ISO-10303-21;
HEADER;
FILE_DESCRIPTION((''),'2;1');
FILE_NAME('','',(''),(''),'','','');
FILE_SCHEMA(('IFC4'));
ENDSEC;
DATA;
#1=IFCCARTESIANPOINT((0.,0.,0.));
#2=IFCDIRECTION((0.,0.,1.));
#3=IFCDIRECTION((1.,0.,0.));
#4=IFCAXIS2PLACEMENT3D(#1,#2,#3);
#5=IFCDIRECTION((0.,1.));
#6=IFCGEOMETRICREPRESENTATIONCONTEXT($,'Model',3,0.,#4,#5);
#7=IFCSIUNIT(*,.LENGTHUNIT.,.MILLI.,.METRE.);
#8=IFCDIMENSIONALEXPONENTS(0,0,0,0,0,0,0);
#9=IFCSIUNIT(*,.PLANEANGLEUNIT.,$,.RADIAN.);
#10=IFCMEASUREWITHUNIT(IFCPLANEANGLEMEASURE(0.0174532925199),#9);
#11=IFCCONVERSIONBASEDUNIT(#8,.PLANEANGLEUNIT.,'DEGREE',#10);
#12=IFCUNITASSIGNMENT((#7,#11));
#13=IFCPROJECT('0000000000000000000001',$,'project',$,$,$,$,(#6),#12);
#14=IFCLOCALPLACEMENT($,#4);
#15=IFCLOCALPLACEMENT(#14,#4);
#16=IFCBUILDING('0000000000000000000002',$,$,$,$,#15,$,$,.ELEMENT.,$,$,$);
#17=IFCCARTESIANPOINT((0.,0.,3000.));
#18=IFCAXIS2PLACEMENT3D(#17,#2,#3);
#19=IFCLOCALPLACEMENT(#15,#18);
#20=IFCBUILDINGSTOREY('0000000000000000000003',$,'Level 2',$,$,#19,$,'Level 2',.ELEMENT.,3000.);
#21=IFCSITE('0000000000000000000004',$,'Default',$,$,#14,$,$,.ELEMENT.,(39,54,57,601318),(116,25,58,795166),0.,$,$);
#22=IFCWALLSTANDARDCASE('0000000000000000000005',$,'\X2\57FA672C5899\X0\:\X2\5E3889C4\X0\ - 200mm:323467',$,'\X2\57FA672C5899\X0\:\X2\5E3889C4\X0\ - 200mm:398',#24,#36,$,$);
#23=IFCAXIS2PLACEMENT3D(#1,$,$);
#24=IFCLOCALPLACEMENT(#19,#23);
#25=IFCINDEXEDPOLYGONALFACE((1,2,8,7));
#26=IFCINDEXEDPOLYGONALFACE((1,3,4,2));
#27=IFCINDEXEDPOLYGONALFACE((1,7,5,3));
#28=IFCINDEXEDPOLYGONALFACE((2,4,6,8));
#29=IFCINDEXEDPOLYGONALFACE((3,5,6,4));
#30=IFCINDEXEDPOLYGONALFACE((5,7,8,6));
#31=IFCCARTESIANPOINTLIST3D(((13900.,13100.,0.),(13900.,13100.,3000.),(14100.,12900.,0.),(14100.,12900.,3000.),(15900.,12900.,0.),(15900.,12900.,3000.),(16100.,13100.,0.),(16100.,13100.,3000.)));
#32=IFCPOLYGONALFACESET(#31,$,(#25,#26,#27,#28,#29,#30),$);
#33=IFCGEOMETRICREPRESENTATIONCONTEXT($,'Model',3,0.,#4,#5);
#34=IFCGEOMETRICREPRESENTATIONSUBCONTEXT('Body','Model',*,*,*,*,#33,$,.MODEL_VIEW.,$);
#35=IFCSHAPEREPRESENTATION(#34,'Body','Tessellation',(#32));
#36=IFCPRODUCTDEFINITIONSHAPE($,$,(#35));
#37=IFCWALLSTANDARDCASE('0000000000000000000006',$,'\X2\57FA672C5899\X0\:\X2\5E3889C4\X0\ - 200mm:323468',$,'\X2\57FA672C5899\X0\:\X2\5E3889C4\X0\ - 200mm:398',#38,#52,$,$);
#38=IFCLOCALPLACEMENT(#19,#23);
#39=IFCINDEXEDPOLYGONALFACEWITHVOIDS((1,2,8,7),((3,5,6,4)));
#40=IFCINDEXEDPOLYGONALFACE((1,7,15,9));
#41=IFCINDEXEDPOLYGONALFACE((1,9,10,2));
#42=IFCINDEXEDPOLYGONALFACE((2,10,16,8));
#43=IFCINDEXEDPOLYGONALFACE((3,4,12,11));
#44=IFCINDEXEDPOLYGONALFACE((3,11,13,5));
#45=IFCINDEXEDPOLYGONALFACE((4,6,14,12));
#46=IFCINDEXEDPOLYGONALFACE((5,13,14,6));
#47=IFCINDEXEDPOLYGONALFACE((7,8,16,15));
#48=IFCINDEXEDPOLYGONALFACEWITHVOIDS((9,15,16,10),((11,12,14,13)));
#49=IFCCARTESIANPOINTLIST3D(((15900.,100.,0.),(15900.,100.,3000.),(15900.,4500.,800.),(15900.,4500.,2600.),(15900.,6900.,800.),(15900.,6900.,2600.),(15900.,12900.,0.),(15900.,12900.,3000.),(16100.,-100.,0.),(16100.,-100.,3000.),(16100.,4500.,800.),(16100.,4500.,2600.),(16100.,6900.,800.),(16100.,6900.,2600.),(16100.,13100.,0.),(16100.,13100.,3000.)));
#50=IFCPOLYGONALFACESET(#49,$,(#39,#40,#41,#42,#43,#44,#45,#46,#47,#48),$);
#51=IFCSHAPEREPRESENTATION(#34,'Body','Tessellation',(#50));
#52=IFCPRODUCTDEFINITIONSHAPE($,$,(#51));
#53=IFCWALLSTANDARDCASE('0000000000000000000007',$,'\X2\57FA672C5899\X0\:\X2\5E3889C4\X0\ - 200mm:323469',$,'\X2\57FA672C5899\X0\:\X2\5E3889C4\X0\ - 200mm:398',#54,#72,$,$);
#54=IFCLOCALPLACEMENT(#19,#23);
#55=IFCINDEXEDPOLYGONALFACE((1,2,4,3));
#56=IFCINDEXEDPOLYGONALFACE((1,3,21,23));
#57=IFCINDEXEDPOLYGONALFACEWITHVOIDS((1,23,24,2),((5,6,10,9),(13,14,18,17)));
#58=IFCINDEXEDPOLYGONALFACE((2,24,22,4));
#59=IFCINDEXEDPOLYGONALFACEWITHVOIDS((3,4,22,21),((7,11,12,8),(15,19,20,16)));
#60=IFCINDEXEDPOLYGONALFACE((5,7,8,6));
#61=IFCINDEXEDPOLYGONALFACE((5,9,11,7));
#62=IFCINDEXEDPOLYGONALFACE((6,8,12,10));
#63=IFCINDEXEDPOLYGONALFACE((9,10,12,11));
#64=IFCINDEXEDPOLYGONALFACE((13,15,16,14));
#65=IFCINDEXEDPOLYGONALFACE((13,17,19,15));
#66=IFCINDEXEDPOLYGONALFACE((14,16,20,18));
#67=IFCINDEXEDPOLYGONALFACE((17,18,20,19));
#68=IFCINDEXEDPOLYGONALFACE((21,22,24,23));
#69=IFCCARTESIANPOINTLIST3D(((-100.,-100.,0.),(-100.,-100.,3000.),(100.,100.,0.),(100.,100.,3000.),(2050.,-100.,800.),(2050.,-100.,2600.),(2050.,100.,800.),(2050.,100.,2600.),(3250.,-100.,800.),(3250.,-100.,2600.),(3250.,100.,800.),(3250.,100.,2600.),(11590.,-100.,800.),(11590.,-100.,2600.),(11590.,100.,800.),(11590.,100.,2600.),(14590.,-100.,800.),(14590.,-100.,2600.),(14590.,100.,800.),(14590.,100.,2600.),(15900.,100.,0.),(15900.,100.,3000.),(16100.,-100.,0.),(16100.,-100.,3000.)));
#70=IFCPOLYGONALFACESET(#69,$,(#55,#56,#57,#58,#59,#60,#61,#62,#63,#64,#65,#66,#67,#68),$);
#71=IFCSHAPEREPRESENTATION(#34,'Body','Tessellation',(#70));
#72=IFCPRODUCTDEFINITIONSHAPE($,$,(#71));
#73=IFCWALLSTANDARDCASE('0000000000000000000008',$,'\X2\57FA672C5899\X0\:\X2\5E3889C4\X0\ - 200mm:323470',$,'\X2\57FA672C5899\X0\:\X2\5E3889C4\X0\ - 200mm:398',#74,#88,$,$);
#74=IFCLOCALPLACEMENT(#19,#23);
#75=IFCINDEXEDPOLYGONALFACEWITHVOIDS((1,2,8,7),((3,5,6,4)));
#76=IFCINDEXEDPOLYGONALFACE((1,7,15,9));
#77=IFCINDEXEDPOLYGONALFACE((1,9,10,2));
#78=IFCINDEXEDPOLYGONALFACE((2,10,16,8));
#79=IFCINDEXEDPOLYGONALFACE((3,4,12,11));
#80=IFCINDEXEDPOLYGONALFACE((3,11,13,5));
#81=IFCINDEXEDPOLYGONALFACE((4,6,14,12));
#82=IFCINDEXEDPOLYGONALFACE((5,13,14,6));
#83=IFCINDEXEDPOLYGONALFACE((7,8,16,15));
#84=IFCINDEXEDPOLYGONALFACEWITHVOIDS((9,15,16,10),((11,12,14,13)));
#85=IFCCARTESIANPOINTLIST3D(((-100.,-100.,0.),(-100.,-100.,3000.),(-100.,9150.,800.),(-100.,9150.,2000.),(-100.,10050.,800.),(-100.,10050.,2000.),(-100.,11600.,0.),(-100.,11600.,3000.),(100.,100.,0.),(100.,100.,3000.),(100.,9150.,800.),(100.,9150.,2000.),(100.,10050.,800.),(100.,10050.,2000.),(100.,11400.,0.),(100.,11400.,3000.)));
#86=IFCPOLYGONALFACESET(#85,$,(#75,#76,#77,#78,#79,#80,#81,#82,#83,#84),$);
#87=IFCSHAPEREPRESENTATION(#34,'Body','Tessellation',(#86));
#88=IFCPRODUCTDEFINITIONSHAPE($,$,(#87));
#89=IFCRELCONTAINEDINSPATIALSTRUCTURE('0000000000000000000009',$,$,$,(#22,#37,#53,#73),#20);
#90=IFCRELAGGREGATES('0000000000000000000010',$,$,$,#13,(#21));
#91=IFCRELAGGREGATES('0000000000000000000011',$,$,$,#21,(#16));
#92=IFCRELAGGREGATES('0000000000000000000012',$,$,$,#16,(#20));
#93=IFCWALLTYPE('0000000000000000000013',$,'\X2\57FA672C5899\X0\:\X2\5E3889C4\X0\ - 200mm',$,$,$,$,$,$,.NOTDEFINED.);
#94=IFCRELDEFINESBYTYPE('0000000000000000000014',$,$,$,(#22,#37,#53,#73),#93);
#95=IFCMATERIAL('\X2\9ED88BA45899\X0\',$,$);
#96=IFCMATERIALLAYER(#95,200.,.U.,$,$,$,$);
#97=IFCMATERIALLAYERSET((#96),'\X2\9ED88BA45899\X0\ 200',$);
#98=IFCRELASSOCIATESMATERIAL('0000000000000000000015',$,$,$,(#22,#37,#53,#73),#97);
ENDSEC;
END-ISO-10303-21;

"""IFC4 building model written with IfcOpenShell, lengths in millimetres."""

from ifc_helpers import new_model, entity, si_unit, converted_unit, direction, frame, origin_with_axes, place, context, subcontext, project, spatial, polyline, outline, extrude, material, layer, layer_set, layer_usage, type_object, element, save


model = new_model("IFC4")

# Units and contexts
model_context_1 = context("Model", 3, precision=0.0, world=origin_with_axes(), true_north=direction((0.0, 1.0)))
model_context_2 = context("Model", 3, precision=0.0, world=origin_with_axes(), true_north=direction((0.0, 1.0)))
body_context = subcontext(model_context_2, "Body", "Model", "MODEL_VIEW")
ifc_project = project(units=[si_unit("LENGTHUNIT", "METRE", prefix="MILLI"), converted_unit("PLANEANGLEUNIT", "DEGREE", entity("IfcPlaneAngleMeasure", 0.0174532925199), si_unit("PLANEANGLEUNIT", "RADIAN"), dimensions=[0, 0, 0, 0, 0, 0, 0])], contexts=[model_context_1])

# Site, building, storey
site_placement = place(None, origin_with_axes())
site = spatial("IfcSite", under=ifc_project, at=site_placement, Name="Default", CompositionType="ELEMENT", RefLatitude=(39, 54, 57, 601318), RefLongitude=(116, 25, 58, 795166), RefElevation=0.0)
building_placement = place(site_placement, origin_with_axes())
building = spatial("IfcBuilding", under=site, at=building_placement, CompositionType="ELEMENT")
storey_placement = place(building_placement, frame((0.0, 0.0, 3000.0), z_axis=(0.0, 0.0, 1.0), x_axis=(1.0, 0.0, 0.0)))
storey = spatial("IfcBuildingStorey", under=building, at=storey_placement, Name="Level 2", LongName="Level 2", CompositionType="ELEMENT", Elevation=3000.0)

# Shared definitions
ifc_material_1 = material(Name="默认墙")
ifc_layer_1 = layer(ifc_material_1, 200.0, ventilated="UNKNOWN")
ifc_layer_set_1 = layer_set([ifc_layer_1], Name="默认墙 200")
wall_type = type_object("IfcWallType", Name="基本墙:常规 - 200mm", PredefinedType="NOTDEFINED")

# Wall
ifc_layer_usage_1 = layer_usage(ifc_layer_set_1, "AXIS2", "POSITIVE", -100.0)
wall_1_placement = place(storey_placement, frame((14000.0, 13000.0, 0.0), z_axis=(0.0, 0.0, 1.0), x_axis=(1.0, 0.0, 0.0)))
element("IfcWallStandardCase", 1, at=wall_1_placement, inside=storey, type_object=wall_type, material=ifc_layer_usage_1, Name="基本墙:常规 - 200mm:323467", ObjectType="基本墙:常规 - 200mm:398", context=body_context, shape_type="SweptSolid", body=[
    extrude(outline(polyline([(100.0, -100.0), (1900.0, -100.0), (2100.0, 100.0), (-100.0, 100.0), (100.0, -100.0)])), origin_with_axes(), (0.0, 0.0, 1.0), 3000.0),
])

# Wall, opening
ifc_layer_usage_2 = layer_usage(ifc_layer_set_1, "AXIS2", "POSITIVE", -100.0)
wall_2_placement = place(storey_placement, frame((16000.0, 13000.0, 0.0), z_axis=(0.0, 0.0, 1.0), x_axis=(0.0, -1.0, 0.0)))
wall_2 = element("IfcWallStandardCase", 2, at=wall_2_placement, inside=storey, type_object=wall_type, material=ifc_layer_usage_2, Name="基本墙:常规 - 200mm:323468", ObjectType="基本墙:常规 - 200mm:398", context=body_context, shape_type="SweptSolid", body=[
    extrude(outline(polyline([(100.0, -100.0), (12900.0, -100.0), (13100.0, 100.0), (-100.0, 100.0), (100.0, -100.0)])), origin_with_axes(), (0.0, 0.0, 1.0), 3000.0),
])
opening_1_placement = place(wall_2_placement, frame((7300.0, 0.0, 800.0), z_axis=(0.0, 0.0, 1.0), x_axis=(1.0, 0.0, 0.0)))
element("IfcOpeningElement", 3, at=opening_1_placement, cuts=wall_2, context=body_context, shape_type="SweptSolid", body=[
    extrude(outline(polyline([(-1200.0, 0.0), (-1200.0, -1800.0), (1200.0, -1800.0), (1200.0, 0.0), (-1200.0, 0.0)])), frame((0.0, -100.0, 0.0), z_axis=(0.0, 1.0, 0.0), x_axis=(1.0, 0.0, 0.0)), (0.0, 0.0, 1.0), 200.0),
])

# Wall, openings
ifc_layer_usage_3 = layer_usage(ifc_layer_set_1, "AXIS2", "POSITIVE", -100.0)
wall_3_placement = place(storey_placement, frame((16000.0, 0.0, 0.0), z_axis=(0.0, 0.0, 1.0), x_axis=(-1.0, 0.0, 0.0)))
wall_3 = element("IfcWallStandardCase", 4, at=wall_3_placement, inside=storey, type_object=wall_type, material=ifc_layer_usage_3, Name="基本墙:常规 - 200mm:323469", ObjectType="基本墙:常规 - 200mm:398", context=body_context, shape_type="SweptSolid", body=[
    extrude(outline(polyline([(100.0, -100.0), (15900.0, -100.0), (16100.0, 100.0), (-100.0, 100.0), (100.0, -100.0)])), origin_with_axes(), (0.0, 0.0, 1.0), 3000.0),
])
opening_2_placement = place(wall_3_placement, frame((13350.0, 0.0, 800.0), z_axis=(0.0, 0.0, 1.0), x_axis=(1.0, 0.0, 0.0)))
element("IfcOpeningElement", 5, at=opening_2_placement, cuts=wall_3, context=body_context, shape_type="SweptSolid", body=[
    extrude(outline(polyline([(-600.0, 0.0), (-600.0, -1800.0), (600.0, -1800.0), (600.0, 0.0), (-600.0, 0.0)])), frame((0.0, -100.0, 0.0), z_axis=(0.0, 1.0, 0.0), x_axis=(1.0, 0.0, 0.0)), (0.0, 0.0, 1.0), 200.0),
])
opening_3_placement = place(wall_3_placement, frame((2910.0, 0.0, 800.0), z_axis=(0.0, 0.0, 1.0), x_axis=(1.0, 0.0, 0.0)))
element("IfcOpeningElement", 6, at=opening_3_placement, cuts=wall_3, context=body_context, shape_type="SweptSolid", body=[
    extrude(outline(polyline([(-1500.0, 0.0), (-1500.0, -1800.0), (1500.0, -1800.0), (1500.0, 0.0), (-1500.0, 0.0)])), frame((0.0, -100.0, 0.0), z_axis=(0.0, 1.0, 0.0), x_axis=(1.0, 0.0, 0.0)), (0.0, 0.0, 1.0), 200.0),
])

# Wall, opening
ifc_layer_usage_4 = layer_usage(ifc_layer_set_1, "AXIS2", "POSITIVE", -100.0)
wall_4_placement = place(storey_placement, frame((0.0, 0.0, 0.0), z_axis=(0.0, 0.0, 1.0), x_axis=(0.0, 1.0, 0.0)))
wall_4 = element("IfcWallStandardCase", 7, at=wall_4_placement, inside=storey, type_object=wall_type, material=ifc_layer_usage_4, Name="基本墙:常规 - 200mm:323470", ObjectType="基本墙:常规 - 200mm:398", context=body_context, shape_type="SweptSolid", body=[
    extrude(outline(polyline([(100.0, -100.0), (11400.0, -100.0), (11600.0, 100.0), (-100.0, 100.0), (100.0, -100.0)])), origin_with_axes(), (0.0, 0.0, 1.0), 3000.0),
])
opening_4_placement = place(wall_4_placement, frame((9600.0, 0.0, 800.0), z_axis=(0.0, 0.0, 1.0), x_axis=(1.0, 0.0, 0.0)))
element("IfcOpeningElement", 8, at=opening_4_placement, cuts=wall_4, context=body_context, shape_type="SweptSolid", body=[
    extrude(outline(polyline([(450.0, -1200.0), (450.0, 0.0), (-450.0, 0.0), (-450.0, -1200.0), (450.0, -1200.0)])), frame((0.0, 100.0, 0.0), z_axis=(0.0, -1.0, 0.0), x_axis=(-1.0, 0.0, 0.0)), (0.0, 0.0, 1.0), 200.0),
])

save(model, "model.ifc")
